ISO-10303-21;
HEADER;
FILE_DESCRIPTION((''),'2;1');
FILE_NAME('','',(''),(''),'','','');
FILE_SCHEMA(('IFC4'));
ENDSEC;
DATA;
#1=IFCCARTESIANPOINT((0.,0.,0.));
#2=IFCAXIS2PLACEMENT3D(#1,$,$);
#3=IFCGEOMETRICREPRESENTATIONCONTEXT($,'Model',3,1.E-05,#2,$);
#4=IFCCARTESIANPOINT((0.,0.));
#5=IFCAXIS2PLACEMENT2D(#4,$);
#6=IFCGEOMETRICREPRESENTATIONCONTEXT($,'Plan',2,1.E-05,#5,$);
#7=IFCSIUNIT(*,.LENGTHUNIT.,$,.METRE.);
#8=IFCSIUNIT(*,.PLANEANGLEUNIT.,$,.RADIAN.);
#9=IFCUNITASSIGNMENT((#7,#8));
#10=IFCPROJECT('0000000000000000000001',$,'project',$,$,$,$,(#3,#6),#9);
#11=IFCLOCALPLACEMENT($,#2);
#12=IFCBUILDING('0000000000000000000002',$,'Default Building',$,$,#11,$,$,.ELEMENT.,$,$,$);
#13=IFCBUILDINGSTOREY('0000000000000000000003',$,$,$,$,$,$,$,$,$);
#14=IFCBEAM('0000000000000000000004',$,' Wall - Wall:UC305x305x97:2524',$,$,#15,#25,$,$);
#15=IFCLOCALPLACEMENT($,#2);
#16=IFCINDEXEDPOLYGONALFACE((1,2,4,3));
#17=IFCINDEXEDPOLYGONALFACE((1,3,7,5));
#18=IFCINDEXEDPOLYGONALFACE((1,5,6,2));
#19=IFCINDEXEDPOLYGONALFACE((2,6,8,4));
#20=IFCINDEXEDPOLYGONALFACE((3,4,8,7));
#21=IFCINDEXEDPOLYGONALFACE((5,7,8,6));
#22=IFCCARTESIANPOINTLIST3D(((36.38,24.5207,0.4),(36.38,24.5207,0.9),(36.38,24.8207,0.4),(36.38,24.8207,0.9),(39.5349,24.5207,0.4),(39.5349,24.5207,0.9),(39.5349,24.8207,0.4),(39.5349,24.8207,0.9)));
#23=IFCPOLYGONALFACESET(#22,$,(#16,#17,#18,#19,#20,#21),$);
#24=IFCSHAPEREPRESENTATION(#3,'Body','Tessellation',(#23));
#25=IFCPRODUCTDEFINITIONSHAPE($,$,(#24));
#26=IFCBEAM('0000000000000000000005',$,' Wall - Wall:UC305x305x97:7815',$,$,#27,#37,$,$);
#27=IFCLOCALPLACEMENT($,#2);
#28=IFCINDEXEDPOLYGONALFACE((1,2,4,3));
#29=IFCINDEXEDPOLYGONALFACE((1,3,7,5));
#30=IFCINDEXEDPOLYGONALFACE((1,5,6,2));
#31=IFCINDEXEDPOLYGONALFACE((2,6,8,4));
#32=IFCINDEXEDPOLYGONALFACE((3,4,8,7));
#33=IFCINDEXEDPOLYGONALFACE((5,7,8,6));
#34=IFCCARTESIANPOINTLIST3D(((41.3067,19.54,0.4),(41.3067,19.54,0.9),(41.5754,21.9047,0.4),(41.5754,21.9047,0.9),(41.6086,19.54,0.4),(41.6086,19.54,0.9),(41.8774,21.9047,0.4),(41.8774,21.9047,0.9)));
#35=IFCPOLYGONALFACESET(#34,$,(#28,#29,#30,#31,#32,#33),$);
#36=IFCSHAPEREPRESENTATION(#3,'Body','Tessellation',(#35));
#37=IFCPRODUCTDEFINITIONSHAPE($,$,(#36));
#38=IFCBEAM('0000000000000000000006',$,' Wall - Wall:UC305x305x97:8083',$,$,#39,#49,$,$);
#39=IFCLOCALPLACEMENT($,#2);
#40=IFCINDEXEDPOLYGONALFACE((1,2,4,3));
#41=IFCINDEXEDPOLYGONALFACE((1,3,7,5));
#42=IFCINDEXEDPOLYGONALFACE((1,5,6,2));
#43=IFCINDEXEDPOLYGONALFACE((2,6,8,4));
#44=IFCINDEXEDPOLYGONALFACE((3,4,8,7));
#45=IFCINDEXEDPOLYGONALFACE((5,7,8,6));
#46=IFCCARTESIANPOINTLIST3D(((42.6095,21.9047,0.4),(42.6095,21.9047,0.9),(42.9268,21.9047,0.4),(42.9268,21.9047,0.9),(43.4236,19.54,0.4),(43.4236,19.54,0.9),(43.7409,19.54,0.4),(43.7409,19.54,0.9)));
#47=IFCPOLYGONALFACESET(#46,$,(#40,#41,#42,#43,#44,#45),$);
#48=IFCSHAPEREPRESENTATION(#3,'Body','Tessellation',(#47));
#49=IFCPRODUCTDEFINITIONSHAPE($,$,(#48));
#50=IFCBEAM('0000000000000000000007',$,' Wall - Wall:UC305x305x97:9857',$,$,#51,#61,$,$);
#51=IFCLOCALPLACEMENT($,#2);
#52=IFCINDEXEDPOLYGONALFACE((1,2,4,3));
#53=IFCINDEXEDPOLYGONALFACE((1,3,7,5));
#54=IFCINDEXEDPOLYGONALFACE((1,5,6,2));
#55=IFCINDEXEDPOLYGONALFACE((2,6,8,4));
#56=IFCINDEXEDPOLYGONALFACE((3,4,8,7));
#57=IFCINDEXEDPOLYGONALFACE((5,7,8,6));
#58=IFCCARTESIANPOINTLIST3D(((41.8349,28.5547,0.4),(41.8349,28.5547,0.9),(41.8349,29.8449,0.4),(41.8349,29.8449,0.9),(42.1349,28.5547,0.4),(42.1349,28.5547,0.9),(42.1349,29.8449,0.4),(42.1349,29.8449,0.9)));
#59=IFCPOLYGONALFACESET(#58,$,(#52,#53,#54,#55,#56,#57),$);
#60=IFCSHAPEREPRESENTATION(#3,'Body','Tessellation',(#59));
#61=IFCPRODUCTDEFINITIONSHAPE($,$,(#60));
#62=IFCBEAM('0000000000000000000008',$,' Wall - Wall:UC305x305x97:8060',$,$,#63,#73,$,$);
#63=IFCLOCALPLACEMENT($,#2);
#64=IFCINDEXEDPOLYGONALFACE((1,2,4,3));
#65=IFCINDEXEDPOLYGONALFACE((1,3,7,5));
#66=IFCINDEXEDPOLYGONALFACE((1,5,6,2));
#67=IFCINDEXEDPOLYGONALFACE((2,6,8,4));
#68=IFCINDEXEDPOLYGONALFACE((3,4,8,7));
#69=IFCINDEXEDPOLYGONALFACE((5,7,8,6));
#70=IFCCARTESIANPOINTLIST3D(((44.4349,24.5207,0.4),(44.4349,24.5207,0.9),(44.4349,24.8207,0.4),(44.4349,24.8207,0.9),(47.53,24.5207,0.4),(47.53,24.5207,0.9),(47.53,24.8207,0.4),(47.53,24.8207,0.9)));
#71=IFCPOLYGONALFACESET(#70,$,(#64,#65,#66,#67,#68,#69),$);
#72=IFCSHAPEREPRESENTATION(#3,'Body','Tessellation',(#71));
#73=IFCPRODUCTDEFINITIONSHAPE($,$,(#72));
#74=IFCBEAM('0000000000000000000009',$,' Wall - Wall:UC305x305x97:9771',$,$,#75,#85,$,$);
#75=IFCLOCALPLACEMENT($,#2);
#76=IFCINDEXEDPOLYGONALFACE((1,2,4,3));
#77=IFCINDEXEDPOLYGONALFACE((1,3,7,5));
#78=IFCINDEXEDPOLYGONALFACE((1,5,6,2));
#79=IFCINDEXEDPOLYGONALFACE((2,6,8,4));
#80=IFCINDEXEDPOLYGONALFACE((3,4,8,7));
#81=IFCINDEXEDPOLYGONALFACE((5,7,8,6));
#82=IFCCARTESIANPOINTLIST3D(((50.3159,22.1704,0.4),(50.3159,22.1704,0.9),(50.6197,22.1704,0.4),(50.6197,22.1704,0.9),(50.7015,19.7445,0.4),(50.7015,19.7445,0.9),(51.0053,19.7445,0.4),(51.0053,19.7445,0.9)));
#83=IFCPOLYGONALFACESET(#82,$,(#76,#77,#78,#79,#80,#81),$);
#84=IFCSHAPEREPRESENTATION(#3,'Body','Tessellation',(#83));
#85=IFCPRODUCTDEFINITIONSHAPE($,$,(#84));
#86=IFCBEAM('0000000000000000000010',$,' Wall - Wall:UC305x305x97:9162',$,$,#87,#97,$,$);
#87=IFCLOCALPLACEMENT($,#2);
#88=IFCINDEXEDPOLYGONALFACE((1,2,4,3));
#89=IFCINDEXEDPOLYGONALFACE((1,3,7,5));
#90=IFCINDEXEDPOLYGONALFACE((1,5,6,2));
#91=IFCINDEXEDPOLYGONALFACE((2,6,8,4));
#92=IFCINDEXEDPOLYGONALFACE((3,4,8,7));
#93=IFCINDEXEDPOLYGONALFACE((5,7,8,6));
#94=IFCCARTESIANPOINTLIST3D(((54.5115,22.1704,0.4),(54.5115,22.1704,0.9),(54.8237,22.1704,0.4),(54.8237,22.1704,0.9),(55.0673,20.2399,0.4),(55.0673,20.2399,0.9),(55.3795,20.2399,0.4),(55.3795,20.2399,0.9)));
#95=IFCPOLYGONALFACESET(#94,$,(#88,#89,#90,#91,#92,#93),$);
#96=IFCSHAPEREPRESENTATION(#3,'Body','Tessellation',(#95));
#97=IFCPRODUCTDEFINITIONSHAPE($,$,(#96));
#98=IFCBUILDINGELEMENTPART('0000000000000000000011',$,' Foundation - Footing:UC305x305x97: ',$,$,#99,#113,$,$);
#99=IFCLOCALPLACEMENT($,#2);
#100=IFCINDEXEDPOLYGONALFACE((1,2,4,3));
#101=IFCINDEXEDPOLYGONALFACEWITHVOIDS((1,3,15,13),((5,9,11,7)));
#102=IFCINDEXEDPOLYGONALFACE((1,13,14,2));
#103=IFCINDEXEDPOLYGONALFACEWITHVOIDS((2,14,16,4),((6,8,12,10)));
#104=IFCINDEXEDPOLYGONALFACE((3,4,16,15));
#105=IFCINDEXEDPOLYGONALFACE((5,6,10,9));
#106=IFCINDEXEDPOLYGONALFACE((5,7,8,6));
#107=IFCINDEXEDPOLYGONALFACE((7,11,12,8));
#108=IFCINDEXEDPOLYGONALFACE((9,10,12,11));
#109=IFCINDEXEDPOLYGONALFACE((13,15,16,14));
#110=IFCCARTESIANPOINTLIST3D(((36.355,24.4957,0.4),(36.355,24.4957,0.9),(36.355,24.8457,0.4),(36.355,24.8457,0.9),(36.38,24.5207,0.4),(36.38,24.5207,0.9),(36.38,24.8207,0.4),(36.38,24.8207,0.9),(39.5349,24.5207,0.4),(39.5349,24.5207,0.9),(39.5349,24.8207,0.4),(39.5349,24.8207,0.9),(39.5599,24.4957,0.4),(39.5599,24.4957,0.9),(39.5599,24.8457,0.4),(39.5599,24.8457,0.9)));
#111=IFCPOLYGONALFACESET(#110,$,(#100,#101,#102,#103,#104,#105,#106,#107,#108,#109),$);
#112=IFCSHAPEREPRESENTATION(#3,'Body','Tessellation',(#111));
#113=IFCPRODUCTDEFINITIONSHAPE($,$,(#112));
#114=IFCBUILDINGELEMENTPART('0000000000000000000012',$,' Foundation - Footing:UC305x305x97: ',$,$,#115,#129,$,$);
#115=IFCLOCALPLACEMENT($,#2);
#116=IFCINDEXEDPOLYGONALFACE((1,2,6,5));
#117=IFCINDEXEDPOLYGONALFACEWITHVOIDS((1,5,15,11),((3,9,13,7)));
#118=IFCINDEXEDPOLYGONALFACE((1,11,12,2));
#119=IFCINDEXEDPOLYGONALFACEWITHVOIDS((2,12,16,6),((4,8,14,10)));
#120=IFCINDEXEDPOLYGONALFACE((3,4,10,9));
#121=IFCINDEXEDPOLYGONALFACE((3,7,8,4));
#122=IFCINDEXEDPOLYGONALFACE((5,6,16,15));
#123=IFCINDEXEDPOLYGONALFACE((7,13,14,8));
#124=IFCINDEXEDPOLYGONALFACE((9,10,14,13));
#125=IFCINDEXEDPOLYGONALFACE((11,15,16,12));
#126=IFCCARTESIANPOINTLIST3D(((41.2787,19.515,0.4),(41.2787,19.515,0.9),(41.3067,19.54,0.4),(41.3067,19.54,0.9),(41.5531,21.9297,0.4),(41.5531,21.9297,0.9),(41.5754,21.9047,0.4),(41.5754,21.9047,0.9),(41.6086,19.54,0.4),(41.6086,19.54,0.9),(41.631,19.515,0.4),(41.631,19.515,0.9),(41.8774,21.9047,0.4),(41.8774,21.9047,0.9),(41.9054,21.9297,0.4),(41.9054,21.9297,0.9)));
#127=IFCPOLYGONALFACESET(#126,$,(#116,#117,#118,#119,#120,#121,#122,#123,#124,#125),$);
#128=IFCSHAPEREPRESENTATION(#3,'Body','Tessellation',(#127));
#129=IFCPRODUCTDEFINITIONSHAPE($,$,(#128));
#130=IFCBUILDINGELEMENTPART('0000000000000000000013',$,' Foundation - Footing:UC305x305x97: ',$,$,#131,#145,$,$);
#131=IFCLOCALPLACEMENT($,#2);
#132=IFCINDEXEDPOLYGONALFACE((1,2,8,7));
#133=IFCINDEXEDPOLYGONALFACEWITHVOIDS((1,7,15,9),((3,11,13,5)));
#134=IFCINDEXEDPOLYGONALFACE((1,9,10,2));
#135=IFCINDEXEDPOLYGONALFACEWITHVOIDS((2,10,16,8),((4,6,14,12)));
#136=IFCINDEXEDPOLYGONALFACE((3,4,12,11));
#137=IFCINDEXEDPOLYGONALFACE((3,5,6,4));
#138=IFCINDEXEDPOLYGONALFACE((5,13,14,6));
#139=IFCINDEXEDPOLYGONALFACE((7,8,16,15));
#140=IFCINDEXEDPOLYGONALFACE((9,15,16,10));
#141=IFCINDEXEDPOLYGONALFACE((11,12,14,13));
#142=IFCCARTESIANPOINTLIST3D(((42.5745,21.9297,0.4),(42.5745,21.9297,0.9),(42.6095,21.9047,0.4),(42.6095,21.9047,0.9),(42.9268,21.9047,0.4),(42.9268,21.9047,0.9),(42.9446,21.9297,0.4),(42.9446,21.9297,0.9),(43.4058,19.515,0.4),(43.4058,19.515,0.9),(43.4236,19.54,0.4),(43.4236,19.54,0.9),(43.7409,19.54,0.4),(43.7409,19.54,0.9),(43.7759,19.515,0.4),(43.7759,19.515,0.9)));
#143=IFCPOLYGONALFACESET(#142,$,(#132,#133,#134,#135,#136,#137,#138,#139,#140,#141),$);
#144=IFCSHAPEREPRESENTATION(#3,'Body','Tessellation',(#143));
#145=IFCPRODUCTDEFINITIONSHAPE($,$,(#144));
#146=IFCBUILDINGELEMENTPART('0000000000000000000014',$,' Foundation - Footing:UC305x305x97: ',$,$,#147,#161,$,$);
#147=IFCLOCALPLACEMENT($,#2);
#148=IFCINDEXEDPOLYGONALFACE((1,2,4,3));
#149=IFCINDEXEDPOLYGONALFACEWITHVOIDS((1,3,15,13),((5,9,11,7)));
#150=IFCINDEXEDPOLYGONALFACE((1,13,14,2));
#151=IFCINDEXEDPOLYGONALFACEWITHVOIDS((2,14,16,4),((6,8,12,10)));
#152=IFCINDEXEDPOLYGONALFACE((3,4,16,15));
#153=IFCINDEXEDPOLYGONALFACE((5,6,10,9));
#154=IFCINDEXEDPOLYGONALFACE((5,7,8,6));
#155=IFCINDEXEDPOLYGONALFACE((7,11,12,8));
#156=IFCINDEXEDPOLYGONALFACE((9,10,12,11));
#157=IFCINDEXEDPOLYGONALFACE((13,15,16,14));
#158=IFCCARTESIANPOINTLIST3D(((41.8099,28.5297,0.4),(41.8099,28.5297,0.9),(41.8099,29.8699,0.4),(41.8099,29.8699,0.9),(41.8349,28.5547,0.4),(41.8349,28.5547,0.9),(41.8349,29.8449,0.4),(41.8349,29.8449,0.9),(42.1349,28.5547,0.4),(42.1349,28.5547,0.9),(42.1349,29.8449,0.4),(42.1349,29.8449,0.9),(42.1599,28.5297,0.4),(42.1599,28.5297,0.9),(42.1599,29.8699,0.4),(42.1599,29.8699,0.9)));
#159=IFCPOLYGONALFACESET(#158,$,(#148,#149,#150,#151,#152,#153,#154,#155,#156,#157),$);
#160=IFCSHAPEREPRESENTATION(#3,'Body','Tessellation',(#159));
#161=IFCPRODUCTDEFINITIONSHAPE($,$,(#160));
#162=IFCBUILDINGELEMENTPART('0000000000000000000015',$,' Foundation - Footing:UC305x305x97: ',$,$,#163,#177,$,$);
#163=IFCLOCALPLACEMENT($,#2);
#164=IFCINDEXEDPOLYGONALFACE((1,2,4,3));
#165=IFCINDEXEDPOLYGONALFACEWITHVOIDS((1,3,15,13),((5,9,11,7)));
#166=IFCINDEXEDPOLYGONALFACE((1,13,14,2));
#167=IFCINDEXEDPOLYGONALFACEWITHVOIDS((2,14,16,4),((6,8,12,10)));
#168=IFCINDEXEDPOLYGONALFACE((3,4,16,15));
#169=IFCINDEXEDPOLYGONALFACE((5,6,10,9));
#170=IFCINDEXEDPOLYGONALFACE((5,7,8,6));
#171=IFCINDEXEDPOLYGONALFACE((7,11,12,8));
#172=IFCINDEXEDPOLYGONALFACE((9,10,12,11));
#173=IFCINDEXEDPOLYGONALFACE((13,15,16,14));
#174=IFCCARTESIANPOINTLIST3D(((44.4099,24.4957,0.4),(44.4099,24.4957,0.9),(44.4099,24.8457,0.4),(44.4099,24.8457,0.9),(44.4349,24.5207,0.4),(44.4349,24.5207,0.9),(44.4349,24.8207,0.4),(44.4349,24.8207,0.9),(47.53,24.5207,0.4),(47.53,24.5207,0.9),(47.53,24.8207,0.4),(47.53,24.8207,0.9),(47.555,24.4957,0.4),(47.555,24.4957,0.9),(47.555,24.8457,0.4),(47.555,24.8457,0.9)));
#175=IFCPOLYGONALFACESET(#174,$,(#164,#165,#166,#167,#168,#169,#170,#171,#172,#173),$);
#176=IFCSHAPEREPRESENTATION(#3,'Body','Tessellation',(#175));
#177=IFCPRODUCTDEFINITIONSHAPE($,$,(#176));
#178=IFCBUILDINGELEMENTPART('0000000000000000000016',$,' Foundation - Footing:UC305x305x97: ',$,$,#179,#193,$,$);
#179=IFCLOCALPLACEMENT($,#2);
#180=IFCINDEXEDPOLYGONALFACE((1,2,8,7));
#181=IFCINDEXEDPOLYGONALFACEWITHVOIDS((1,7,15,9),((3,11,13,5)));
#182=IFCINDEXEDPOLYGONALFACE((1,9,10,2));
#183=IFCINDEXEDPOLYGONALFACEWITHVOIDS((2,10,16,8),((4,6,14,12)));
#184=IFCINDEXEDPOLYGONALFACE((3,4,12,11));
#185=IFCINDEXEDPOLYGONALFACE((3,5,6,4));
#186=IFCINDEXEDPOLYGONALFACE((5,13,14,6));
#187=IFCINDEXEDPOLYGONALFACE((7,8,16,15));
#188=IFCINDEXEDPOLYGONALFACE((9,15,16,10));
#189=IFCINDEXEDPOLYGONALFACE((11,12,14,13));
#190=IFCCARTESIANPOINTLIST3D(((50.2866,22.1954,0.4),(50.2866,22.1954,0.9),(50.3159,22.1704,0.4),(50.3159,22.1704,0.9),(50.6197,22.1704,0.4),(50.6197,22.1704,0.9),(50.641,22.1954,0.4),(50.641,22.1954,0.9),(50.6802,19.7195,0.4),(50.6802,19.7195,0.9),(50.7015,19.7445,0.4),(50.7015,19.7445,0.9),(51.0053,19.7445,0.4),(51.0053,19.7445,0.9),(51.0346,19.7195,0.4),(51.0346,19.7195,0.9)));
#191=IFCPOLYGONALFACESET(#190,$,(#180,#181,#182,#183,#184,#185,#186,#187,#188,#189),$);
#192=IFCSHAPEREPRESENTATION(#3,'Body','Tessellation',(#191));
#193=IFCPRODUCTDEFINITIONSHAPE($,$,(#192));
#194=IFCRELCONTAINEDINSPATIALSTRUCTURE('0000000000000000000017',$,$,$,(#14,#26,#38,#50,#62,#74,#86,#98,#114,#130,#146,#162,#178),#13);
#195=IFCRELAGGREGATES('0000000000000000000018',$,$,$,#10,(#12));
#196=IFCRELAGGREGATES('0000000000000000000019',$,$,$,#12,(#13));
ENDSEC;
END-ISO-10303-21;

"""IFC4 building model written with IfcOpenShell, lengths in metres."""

from ifc_helpers import new_model, si_unit, origin, origin_2d, place, context, project, spatial, polyline, outline, extrude, element, save


model = new_model("IFC4")

# Units and contexts
model_context = context("Model", 3, precision=1e-05, world=origin())
plan_context = context("Plan", 2, precision=1e-05, world=origin_2d())
ifc_project = project(units=[si_unit("LENGTHUNIT", "METRE"), si_unit("PLANEANGLEUNIT", "RADIAN")], contexts=[model_context, plan_context])

# Building, storey
building_placement = place(None, origin())
building = spatial("IfcBuilding", under=ifc_project, at=building_placement, Name="Default Building", CompositionType="ELEMENT")
storey = spatial("IfcBuildingStorey", under=building)

# Beams
element("IfcBeam", 1, inside=storey, Name=" Wall - Wall:UC305x305x97:2524", context=model_context, shape_type="SweptSolid", body=[
    extrude(outline(polyline([(36.38, 24.5207, 0.4), (36.38, 24.8207, 0.4), (39.5349, 24.8207, 0.4), (39.5349, 24.5207, 0.4), (36.38, 24.5207, 0.4)])), None, (0.0, 0.0, 1.0), 0.5),
])
element("IfcBeam", 2, inside=storey, Name=" Wall - Wall:UC305x305x97:7815", context=model_context, shape_type="SweptSolid", body=[
    extrude(outline(polyline([(41.3067, 19.54, 0.4), (41.6086, 19.54, 0.4), (41.8774, 21.9047, 0.4), (41.5754, 21.9047, 0.4), (41.3067, 19.54, 0.4)])), None, (0.0, 0.0, 1.0), 0.5),
])
element("IfcBeam", 3, inside=storey, Name=" Wall - Wall:UC305x305x97:8083", context=model_context, shape_type="SweptSolid", body=[
    extrude(outline(polyline([(43.4236, 19.54, 0.4), (43.7409, 19.54, 0.4), (42.9268, 21.9047, 0.4), (42.6095, 21.9047, 0.4), (43.4236, 19.54, 0.4)])), None, (0.0, 0.0, 1.0), 0.5),
])
element("IfcBeam", 4, inside=storey, Name=" Wall - Wall:UC305x305x97:9857", context=model_context, shape_type="SweptSolid", body=[
    extrude(outline(polyline([(41.8349, 28.5547, 0.4), (42.1349, 28.5547, 0.4), (42.1349, 29.8449, 0.4), (41.8349, 29.8449, 0.4), (41.8349, 28.5547, 0.4)])), None, (0.0, 0.0, 1.0), 0.5),
])
element("IfcBeam", 5, inside=storey, Name=" Wall - Wall:UC305x305x97:8060", context=model_context, shape_type="SweptSolid", body=[
    extrude(outline(polyline([(44.4349, 24.5207, 0.4), (44.4349, 24.8207, 0.4), (47.53, 24.8207, 0.4), (47.53, 24.5207, 0.4), (44.4349, 24.5207, 0.4)])), None, (0.0, 0.0, 1.0), 0.5),
])
element("IfcBeam", 6, inside=storey, Name=" Wall - Wall:UC305x305x97:9771", context=model_context, shape_type="SweptSolid", body=[
    extrude(outline(polyline([(50.7015, 19.7445, 0.4), (51.0053, 19.7445, 0.4), (50.6197, 22.1704, 0.4), (50.3159, 22.1704, 0.4), (50.7015, 19.7445, 0.4)])), None, (0.0, 0.0, 1.0), 0.5),
])
element("IfcBeam", 7, inside=storey, Name=" Wall - Wall:UC305x305x97:9162", context=model_context, shape_type="SweptSolid", body=[
    extrude(outline(polyline([(55.0673, 20.2399, 0.4), (55.3795, 20.2399, 0.4), (54.8237, 22.1704, 0.4), (54.5115, 22.1704, 0.4), (55.0673, 20.2399, 0.4)])), None, (0.0, 0.0, 1.0), 0.5),
])

# Building element parts, openings
building_element_part_1 = element("IfcBuildingElementPart", 8, inside=storey, Name=" Foundation - Footing:UC305x305x97: ", context=model_context, shape_type="SweptSolid", body=[
    extrude(outline(polyline([(36.355, 24.4957, 0.4), (36.355, 24.8457, 0.4), (39.5599, 24.8457, 0.4), (39.5599, 24.4957, 0.4), (36.355, 24.4957, 0.4)])), None, (0.0, 0.0, 1.0), 0.5),
])
element("IfcOpeningElement", 9, inside=storey, cuts=building_element_part_1, context=model_context, shape_type="SweptSolid", body=[
    extrude(outline(polyline([(36.38, 24.5207, 0.4), (36.38, 24.8207, 0.4), (39.5349, 24.8207, 0.4), (39.5349, 24.5207, 0.4), (36.38, 24.5207, 0.4)])), None, (0.0, 0.0, 1.0), 0.5),
])
building_element_part_2 = element("IfcBuildingElementPart", 10, inside=storey, Name=" Foundation - Footing:UC305x305x97: ", context=model_context, shape_type="SweptSolid", body=[
    extrude(outline(polyline([(41.2787, 19.515, 0.4), (41.631, 19.515, 0.4), (41.9054, 21.9297, 0.4), (41.5531, 21.9297, 0.4), (41.2787, 19.515, 0.4)])), None, (0.0, 0.0, 1.0), 0.5),
])
element("IfcOpeningElement", 11, inside=storey, cuts=building_element_part_2, context=model_context, shape_type="SweptSolid", body=[
    extrude(outline(polyline([(41.3067, 19.54, 0.4), (41.6086, 19.54, 0.4), (41.8774, 21.9047, 0.4), (41.5754, 21.9047, 0.4), (41.3067, 19.54, 0.4)])), None, (0.0, 0.0, 1.0), 0.5),
])
building_element_part_3 = element("IfcBuildingElementPart", 12, inside=storey, Name=" Foundation - Footing:UC305x305x97: ", context=model_context, shape_type="SweptSolid", body=[
    extrude(outline(polyline([(43.4058, 19.515, 0.4), (43.7759, 19.515, 0.4), (42.9446, 21.9297, 0.4), (42.5745, 21.9297, 0.4), (43.4058, 19.515, 0.4)])), None, (0.0, 0.0, 1.0), 0.5),
])
element("IfcOpeningElement", 13, inside=storey, cuts=building_element_part_3, context=model_context, shape_type="SweptSolid", body=[
    extrude(outline(polyline([(43.4236, 19.54, 0.4), (43.7409, 19.54, 0.4), (42.9268, 21.9047, 0.4), (42.6095, 21.9047, 0.4), (43.4236, 19.54, 0.4)])), None, (0.0, 0.0, 1.0), 0.5),
])
building_element_part_4 = element("IfcBuildingElementPart", 14, inside=storey, Name=" Foundation - Footing:UC305x305x97: ", context=model_context, shape_type="SweptSolid", body=[
    extrude(outline(polyline([(41.8099, 28.5297, 0.4), (42.1599, 28.5297, 0.4), (42.1599, 29.8699, 0.4), (41.8099, 29.8699, 0.4), (41.8099, 28.5297, 0.4)])), None, (0.0, 0.0, 1.0), 0.5),
])
element("IfcOpeningElement", 15, inside=storey, cuts=building_element_part_4, context=model_context, shape_type="SweptSolid", body=[
    extrude(outline(polyline([(41.8349, 28.5547, 0.4), (42.1349, 28.5547, 0.4), (42.1349, 29.8449, 0.4), (41.8349, 29.8449, 0.4), (41.8349, 28.5547, 0.4)])), None, (0.0, 0.0, 1.0), 0.5),
])
building_element_part_5 = element("IfcBuildingElementPart", 16, inside=storey, Name=" Foundation - Footing:UC305x305x97: ", context=model_context, shape_type="SweptSolid", body=[
    extrude(outline(polyline([(44.4099, 24.4957, 0.4), (44.4099, 24.8457, 0.4), (47.555, 24.8457, 0.4), (47.555, 24.4957, 0.4), (44.4099, 24.4957, 0.4)])), None, (0.0, 0.0, 1.0), 0.5),
])
element("IfcOpeningElement", 17, inside=storey, cuts=building_element_part_5, context=model_context, shape_type="SweptSolid", body=[
    extrude(outline(polyline([(44.4349, 24.5207, 0.4), (44.4349, 24.8207, 0.4), (47.53, 24.8207, 0.4), (47.53, 24.5207, 0.4), (44.4349, 24.5207, 0.4)])), None, (0.0, 0.0, 1.0), 0.5),
])
building_element_part_6 = element("IfcBuildingElementPart", 18, inside=storey, Name=" Foundation - Footing:UC305x305x97: ", context=model_context, shape_type="SweptSolid", body=[
    extrude(outline(polyline([(50.6802, 19.7195, 0.4), (51.0346, 19.7195, 0.4), (50.641, 22.1954, 0.4), (50.2866, 22.1954, 0.4), (50.6802, 19.7195, 0.4)])), None, (0.0, 0.0, 1.0), 0.5),
])
element("IfcOpeningElement", 19, inside=storey, cuts=building_element_part_6, context=model_context, shape_type="SweptSolid", body=[
    extrude(outline(polyline([(50.7015, 19.7445, 0.4), (51.0053, 19.7445, 0.4), (50.6197, 22.1704, 0.4), (50.3159, 22.1704, 0.4), (50.7015, 19.7445, 0.4)])), None, (0.0, 0.0, 1.0), 0.5),
])

save(model, "model.ifc")
